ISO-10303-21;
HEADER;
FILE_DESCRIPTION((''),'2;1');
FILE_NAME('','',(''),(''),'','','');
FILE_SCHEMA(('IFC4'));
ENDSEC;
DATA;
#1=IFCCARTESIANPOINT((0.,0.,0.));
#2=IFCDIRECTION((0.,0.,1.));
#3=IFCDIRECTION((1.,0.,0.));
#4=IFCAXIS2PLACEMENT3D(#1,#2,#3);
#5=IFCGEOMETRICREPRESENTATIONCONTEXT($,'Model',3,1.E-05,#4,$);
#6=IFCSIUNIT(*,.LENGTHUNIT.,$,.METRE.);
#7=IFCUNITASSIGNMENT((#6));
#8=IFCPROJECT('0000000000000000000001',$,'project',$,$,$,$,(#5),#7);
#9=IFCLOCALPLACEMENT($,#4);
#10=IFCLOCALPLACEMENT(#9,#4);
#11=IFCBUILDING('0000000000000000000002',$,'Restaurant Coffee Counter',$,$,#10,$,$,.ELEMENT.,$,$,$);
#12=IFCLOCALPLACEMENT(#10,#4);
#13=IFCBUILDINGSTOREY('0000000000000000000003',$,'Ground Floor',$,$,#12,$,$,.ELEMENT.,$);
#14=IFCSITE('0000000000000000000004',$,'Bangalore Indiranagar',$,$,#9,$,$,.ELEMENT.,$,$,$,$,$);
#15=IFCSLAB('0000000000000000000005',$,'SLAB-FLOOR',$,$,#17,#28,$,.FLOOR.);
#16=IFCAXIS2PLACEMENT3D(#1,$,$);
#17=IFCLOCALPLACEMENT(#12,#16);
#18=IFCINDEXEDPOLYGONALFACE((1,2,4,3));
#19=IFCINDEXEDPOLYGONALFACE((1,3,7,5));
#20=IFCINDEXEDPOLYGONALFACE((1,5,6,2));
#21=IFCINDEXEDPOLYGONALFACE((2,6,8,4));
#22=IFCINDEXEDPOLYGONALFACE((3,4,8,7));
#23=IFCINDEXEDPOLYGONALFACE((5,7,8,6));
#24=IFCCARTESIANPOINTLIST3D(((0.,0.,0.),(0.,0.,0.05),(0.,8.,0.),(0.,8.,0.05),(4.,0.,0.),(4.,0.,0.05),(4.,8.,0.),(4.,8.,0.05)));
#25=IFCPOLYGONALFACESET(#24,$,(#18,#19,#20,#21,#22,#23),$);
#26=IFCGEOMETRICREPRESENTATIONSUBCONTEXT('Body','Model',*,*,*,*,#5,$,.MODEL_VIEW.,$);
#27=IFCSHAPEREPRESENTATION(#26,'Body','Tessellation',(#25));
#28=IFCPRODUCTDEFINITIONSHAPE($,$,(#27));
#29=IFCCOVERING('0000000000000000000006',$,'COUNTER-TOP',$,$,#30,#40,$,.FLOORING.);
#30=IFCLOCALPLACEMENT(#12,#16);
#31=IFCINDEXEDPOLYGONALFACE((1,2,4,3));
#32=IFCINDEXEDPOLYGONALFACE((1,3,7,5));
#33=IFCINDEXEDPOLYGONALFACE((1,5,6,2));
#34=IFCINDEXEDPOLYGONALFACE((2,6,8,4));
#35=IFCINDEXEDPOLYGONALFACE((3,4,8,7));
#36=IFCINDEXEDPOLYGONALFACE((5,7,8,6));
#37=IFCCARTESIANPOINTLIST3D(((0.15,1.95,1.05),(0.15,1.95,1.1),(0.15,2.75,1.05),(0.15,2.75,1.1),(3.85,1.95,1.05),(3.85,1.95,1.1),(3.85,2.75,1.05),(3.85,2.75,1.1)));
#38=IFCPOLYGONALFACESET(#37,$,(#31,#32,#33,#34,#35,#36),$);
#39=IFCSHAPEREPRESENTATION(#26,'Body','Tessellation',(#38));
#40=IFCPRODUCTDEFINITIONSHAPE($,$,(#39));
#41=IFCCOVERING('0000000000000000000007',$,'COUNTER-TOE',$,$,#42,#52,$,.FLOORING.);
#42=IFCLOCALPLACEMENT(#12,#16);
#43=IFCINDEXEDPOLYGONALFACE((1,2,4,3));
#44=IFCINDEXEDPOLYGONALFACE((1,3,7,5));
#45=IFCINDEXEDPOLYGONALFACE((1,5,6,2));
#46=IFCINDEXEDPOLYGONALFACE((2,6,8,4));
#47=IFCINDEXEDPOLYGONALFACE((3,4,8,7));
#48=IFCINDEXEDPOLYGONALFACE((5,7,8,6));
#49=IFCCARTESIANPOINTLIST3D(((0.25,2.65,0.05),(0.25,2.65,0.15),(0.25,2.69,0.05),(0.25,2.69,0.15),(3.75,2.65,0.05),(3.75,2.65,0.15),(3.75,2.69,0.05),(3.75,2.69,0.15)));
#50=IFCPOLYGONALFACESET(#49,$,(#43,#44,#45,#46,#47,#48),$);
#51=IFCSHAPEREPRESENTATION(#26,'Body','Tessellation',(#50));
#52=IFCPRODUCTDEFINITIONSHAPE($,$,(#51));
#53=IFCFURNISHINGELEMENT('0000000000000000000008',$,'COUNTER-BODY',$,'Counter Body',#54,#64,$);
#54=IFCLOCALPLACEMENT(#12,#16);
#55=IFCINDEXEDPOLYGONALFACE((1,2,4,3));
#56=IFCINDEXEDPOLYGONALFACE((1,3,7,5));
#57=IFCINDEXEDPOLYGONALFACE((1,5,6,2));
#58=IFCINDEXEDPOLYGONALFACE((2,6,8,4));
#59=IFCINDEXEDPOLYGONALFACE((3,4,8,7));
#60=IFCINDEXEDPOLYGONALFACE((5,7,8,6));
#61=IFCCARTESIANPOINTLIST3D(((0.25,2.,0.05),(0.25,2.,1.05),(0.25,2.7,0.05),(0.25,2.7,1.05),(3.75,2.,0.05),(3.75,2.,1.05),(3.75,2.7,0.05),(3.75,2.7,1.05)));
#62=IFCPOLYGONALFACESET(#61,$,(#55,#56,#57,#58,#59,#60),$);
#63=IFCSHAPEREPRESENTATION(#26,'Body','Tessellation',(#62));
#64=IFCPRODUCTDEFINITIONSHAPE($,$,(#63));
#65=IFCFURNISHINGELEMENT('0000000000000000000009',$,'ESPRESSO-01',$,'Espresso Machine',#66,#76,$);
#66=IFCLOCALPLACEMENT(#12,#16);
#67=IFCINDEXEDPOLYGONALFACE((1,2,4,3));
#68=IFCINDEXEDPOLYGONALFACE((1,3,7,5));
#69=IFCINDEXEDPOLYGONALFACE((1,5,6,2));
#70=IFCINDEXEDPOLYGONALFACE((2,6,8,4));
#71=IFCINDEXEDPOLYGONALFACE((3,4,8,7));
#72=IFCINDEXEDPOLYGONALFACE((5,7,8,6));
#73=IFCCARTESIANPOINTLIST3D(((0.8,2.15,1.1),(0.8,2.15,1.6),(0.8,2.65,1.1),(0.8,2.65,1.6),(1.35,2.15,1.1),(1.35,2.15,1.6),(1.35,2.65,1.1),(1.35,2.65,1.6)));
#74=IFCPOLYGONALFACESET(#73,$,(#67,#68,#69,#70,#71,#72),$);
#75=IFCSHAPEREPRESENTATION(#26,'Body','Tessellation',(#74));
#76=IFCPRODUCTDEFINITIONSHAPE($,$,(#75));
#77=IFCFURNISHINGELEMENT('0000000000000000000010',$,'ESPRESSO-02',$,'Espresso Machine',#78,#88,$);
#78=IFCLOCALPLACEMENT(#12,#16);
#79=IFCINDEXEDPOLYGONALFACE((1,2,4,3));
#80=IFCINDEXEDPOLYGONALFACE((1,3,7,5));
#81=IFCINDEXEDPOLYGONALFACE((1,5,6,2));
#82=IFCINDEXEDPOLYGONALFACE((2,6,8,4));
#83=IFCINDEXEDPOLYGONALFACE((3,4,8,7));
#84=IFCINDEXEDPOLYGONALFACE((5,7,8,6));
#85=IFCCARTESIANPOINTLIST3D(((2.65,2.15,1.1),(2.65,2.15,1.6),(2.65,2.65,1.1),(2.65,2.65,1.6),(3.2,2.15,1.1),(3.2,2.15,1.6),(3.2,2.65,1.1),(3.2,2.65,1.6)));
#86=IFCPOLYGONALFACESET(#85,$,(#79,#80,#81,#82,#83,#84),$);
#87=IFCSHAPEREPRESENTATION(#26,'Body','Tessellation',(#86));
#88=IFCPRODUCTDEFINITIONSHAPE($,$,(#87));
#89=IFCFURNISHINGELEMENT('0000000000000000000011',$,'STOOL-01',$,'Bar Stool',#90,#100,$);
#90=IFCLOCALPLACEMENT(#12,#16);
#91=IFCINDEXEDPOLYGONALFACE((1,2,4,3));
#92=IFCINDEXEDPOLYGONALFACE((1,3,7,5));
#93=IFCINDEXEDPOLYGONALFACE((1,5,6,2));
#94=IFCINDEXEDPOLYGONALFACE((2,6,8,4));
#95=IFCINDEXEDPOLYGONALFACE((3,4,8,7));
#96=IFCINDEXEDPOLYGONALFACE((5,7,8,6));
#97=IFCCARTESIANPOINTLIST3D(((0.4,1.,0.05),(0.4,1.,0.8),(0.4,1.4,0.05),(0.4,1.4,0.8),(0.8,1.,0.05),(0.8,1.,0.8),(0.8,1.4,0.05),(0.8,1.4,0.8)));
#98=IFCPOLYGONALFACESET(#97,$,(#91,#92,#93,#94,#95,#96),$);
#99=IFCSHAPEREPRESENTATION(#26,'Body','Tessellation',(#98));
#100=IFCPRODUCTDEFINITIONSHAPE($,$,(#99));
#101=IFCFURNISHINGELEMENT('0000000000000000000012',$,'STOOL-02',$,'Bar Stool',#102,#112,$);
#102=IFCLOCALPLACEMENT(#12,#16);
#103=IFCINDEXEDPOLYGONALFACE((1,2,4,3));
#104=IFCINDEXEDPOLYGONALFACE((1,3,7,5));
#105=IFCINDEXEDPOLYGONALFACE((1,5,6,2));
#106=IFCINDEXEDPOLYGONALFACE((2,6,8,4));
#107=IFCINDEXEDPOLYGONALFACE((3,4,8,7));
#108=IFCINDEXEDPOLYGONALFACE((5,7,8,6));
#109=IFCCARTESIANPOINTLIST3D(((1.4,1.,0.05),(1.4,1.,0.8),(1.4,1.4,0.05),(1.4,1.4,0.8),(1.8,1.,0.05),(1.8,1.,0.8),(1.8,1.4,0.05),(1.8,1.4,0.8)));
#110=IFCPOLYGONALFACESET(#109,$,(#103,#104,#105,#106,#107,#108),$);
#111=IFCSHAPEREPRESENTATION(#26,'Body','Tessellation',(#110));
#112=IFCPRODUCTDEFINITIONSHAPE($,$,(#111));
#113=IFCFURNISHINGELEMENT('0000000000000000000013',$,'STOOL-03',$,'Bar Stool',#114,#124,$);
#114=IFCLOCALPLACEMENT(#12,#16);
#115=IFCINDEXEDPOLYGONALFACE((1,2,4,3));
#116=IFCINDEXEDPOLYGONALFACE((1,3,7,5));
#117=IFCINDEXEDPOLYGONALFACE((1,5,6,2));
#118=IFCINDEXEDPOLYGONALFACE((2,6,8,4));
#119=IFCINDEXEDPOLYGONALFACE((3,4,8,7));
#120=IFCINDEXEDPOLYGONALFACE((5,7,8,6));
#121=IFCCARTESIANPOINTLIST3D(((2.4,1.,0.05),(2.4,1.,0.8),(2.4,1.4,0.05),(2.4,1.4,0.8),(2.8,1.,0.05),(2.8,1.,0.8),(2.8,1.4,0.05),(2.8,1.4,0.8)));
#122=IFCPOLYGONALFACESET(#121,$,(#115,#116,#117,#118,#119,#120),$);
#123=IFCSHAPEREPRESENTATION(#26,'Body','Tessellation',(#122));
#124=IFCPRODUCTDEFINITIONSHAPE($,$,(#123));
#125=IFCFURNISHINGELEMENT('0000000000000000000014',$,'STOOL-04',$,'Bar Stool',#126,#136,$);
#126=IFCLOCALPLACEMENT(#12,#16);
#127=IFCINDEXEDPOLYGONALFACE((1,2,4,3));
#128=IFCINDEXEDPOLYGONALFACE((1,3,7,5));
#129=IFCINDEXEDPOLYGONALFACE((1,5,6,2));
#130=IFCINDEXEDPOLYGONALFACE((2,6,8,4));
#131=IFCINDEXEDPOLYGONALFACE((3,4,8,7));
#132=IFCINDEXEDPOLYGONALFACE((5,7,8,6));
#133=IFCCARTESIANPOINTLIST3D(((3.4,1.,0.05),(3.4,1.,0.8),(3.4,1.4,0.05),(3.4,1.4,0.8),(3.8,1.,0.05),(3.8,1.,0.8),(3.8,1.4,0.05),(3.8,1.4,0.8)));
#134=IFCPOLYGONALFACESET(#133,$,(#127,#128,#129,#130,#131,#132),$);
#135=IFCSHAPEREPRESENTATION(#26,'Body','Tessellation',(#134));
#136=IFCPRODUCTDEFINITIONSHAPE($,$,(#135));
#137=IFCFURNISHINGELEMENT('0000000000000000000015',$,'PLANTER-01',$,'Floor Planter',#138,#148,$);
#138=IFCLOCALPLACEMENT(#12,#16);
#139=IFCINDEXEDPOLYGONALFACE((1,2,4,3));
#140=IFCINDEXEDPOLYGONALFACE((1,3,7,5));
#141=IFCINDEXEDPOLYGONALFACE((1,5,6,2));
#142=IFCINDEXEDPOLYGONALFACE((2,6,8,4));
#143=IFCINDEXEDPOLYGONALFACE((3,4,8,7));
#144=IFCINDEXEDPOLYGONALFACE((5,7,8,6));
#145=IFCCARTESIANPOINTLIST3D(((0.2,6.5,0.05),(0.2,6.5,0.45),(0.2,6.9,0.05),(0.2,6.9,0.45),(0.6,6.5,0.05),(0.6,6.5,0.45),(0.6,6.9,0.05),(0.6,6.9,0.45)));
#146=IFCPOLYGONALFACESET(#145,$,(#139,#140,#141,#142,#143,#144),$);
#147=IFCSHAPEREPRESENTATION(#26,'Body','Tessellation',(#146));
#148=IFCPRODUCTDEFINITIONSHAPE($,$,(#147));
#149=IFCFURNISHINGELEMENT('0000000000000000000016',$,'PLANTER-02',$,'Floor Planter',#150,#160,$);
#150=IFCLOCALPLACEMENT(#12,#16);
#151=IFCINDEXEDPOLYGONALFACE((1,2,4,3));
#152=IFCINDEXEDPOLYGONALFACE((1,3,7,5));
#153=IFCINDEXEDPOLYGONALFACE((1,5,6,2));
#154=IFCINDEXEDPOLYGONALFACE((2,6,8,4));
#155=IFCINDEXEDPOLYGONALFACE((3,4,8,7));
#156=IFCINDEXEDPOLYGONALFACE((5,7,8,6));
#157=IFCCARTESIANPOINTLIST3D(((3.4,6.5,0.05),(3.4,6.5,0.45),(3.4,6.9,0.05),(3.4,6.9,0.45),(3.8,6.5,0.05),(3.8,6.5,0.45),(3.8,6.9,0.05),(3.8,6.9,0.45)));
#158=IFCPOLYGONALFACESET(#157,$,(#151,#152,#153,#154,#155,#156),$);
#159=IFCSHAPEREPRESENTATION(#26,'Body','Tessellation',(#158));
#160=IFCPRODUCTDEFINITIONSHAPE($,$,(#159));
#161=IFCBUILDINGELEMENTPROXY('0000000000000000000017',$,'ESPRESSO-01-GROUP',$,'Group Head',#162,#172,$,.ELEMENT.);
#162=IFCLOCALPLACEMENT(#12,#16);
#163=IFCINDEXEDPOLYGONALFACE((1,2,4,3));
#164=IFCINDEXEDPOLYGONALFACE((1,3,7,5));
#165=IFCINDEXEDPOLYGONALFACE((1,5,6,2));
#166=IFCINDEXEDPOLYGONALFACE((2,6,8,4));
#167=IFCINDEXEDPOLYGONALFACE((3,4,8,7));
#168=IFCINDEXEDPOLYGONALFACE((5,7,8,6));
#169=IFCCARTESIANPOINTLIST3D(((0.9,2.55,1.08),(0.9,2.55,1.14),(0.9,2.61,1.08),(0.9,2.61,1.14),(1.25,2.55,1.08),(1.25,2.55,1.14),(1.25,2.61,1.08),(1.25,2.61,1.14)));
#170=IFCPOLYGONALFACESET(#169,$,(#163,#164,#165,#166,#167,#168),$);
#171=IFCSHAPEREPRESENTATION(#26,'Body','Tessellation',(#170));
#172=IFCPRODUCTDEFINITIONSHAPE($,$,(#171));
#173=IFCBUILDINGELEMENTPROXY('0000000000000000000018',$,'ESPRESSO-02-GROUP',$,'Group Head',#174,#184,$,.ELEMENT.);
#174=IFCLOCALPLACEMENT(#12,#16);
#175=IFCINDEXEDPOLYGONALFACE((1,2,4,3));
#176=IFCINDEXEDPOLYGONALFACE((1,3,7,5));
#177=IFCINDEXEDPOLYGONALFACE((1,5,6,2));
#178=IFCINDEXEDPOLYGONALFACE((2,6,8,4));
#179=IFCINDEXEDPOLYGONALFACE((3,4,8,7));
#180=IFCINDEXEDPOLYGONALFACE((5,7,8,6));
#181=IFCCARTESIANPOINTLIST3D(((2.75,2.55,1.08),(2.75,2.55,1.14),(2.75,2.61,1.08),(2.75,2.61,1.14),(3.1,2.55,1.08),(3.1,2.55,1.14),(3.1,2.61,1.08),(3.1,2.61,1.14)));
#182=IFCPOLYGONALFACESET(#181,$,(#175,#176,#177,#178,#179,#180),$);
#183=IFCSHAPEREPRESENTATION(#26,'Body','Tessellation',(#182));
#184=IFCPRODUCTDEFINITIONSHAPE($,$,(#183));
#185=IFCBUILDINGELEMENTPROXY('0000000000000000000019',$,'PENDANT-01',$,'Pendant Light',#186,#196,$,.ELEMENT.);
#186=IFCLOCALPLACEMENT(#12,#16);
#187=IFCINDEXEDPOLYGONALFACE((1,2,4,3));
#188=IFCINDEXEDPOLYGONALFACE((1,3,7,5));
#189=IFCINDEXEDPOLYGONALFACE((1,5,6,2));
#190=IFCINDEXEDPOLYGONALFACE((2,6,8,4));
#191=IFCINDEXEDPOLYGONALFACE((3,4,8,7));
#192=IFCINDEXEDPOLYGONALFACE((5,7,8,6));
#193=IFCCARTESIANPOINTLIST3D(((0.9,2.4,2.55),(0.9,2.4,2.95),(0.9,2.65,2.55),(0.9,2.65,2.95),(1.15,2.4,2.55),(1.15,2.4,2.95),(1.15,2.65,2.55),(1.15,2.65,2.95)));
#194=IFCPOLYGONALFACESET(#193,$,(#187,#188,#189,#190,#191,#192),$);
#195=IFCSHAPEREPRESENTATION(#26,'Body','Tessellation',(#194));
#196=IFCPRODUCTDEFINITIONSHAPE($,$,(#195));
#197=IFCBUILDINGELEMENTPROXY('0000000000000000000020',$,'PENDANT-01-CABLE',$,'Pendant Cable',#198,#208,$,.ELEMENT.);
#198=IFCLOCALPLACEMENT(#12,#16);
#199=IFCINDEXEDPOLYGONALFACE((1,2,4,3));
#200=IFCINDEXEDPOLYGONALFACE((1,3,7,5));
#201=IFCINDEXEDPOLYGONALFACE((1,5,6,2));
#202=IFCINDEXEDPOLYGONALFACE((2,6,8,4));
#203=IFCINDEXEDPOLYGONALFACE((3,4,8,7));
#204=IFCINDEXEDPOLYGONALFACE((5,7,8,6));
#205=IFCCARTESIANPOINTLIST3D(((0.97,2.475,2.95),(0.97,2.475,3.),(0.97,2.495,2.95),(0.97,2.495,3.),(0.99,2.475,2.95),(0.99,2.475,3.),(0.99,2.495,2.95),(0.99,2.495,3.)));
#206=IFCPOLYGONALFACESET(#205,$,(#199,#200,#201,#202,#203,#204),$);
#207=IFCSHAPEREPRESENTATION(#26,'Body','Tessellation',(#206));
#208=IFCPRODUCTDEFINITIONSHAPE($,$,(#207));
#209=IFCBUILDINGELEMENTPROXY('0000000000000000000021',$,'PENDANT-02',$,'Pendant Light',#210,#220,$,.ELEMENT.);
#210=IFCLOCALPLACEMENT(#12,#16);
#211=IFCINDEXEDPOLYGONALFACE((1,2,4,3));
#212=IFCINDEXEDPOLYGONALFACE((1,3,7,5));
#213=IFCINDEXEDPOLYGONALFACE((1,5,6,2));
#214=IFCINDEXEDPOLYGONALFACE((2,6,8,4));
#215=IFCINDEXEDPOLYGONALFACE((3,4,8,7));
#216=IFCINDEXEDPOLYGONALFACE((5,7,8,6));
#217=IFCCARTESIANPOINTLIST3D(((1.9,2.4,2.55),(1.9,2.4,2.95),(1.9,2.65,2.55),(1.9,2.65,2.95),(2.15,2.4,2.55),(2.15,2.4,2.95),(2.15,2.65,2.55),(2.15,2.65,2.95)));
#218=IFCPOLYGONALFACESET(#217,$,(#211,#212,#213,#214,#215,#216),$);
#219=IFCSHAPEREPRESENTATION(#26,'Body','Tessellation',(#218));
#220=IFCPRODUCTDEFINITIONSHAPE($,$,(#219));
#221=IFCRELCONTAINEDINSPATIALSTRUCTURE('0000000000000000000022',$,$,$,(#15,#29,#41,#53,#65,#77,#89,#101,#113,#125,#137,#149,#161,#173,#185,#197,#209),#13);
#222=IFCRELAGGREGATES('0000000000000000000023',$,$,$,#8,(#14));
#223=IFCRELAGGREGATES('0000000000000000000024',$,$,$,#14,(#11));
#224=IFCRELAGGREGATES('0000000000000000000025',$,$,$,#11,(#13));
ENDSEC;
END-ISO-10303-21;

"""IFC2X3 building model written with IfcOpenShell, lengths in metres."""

from ifc_helpers import new_model, si_unit, frame, frame_2d, origin, origin_with_axes, place, context, subcontext, project, spatial, rectangle, extrude, element, save


model = new_model("IFC2X3")

# Units and contexts
model_context = context("Model", 3, precision=1e-05, world=origin_with_axes())
body_context = subcontext(model_context, "Body", "Model", "MODEL_VIEW")
ifc_project = project(units=[si_unit("LENGTHUNIT", "METRE")], contexts=[model_context])

# Site, building, storey
site_placement = place(None, origin_with_axes())
site = spatial("IfcSite", under=ifc_project, at=site_placement, Name="Bangalore Indiranagar", CompositionType="ELEMENT")
building_placement = place(site_placement, origin_with_axes())
building = spatial("IfcBuilding", under=site, at=building_placement, Name="Restaurant Coffee Counter", CompositionType="ELEMENT")
storey_placement = place(building_placement, origin_with_axes())
storey = spatial("IfcBuildingStorey", under=building, at=storey_placement, Name="Ground Floor", CompositionType="ELEMENT")

# Slab
slab_placement = place(storey_placement, origin_with_axes())
element("IfcSlab", 1, at=slab_placement, inside=storey, Name="SLAB-FLOOR", PredefinedType="FLOOR", context=body_context, shape_type="SweptSolid", body=[
    extrude(rectangle(XDim=4.0, YDim=8.0, at=frame_2d((2.0, 4.0))), origin(), (0.0, 0.0, 1.0), 0.05),
])

# Coverings
covering_1_placement = place(storey_placement, frame((0.15, 1.95, 1.05), z_axis=(0.0, 0.0, 1.0), x_axis=(1.0, 0.0, 0.0)))
element("IfcCovering", 2, at=covering_1_placement, inside=storey, Name="COUNTER-TOP", PredefinedType="FLOORING", context=body_context, shape_type="SweptSolid", body=[
    extrude(rectangle(XDim=3.7, YDim=0.8, at=frame_2d((1.85, 0.4))), origin(), (0.0, 0.0, 1.0), 0.05),
])
covering_2_placement = place(storey_placement, frame((0.25, 2.65, 0.05), z_axis=(0.0, 0.0, 1.0), x_axis=(1.0, 0.0, 0.0)))
element("IfcCovering", 3, at=covering_2_placement, inside=storey, Name="COUNTER-TOE", PredefinedType="FLOORING", context=body_context, shape_type="SweptSolid", body=[
    extrude(rectangle(XDim=3.5, YDim=0.04, at=frame_2d((1.75, 0.02))), origin(), (0.0, 0.0, 1.0), 0.1),
])

# Furnishing elements
furnishing_placement = place(storey_placement, frame((0.25, 2.0, 0.05), z_axis=(0.0, 0.0, 1.0), x_axis=(1.0, 0.0, 0.0)))
element("IfcFurnishingElement", 4, at=furnishing_placement, inside=storey, Name="COUNTER-BODY", ObjectType="Counter Body", context=body_context, shape_type="SweptSolid", body=[
    extrude(rectangle(XDim=3.5, YDim=0.7, at=frame_2d((1.75, 0.35))), origin(), (0.0, 0.0, 1.0), 1.0),
])
for number, where, z_axis, x_axis, name in (
    (5, (0.8, 2.15, 1.1), (0.0, 0.0, 1.0), (1.0, 0.0, 0.0), "ESPRESSO-01"),
    (6, (2.65, 2.15, 1.1), (0.0, 0.0, 1.0), (1.0, 0.0, 0.0), "ESPRESSO-02"),
):
    element("IfcFurnishingElement", number, at=place(storey_placement, frame(where, z_axis=z_axis, x_axis=x_axis)), inside=storey, Name=name, ObjectType="Espresso Machine", context=body_context, shape_type="SweptSolid", body=[
        extrude(rectangle(XDim=0.55, YDim=0.5, at=frame_2d((0.275, 0.25))), origin(), (0.0, 0.0, 1.0), 0.5),
    ])
for number, where, z_axis, x_axis, name in (
    (7, (0.4, 1.0, 0.05), (0.0, 0.0, 1.0), (1.0, 0.0, 0.0), "STOOL-01"),
    (8, (1.4, 1.0, 0.05), (0.0, 0.0, 1.0), (1.0, 0.0, 0.0), "STOOL-02"),
    (9, (2.4, 1.0, 0.05), (0.0, 0.0, 1.0), (1.0, 0.0, 0.0), "STOOL-03"),
    (10, (3.4, 1.0, 0.05), (0.0, 0.0, 1.0), (1.0, 0.0, 0.0), "STOOL-04"),
):
    element("IfcFurnishingElement", number, at=place(storey_placement, frame(where, z_axis=z_axis, x_axis=x_axis)), inside=storey, Name=name, ObjectType="Bar Stool", context=body_context, shape_type="SweptSolid", body=[
        extrude(rectangle(XDim=0.4, YDim=0.4, at=frame_2d((0.2, 0.2))), origin(), (0.0, 0.0, 1.0), 0.75),
    ])
for number, where, z_axis, x_axis, name in (
    (11, (0.2, 6.5, 0.05), (0.0, 0.0, 1.0), (1.0, 0.0, 0.0), "PLANTER-01"),
    (12, (3.4, 6.5, 0.05), (0.0, 0.0, 1.0), (1.0, 0.0, 0.0), "PLANTER-02"),
):
    element("IfcFurnishingElement", number, at=place(storey_placement, frame(where, z_axis=z_axis, x_axis=x_axis)), inside=storey, Name=name, ObjectType="Floor Planter", context=body_context, shape_type="SweptSolid", body=[
        extrude(rectangle(XDim=0.4, YDim=0.4, at=frame_2d((0.2, 0.2))), origin(), (0.0, 0.0, 1.0), 0.4),
    ])

# Building element proxies
for number, where, z_axis, x_axis, name in (
    (13, (0.9, 2.55, 1.08), (0.0, 0.0, 1.0), (1.0, 0.0, 0.0), "ESPRESSO-01-GROUP"),
    (14, (2.75, 2.55, 1.08), (0.0, 0.0, 1.0), (1.0, 0.0, 0.0), "ESPRESSO-02-GROUP"),
):
    element("IfcBuildingElementProxy", number, at=place(storey_placement, frame(where, z_axis=z_axis, x_axis=x_axis)), inside=storey, Name=name, ObjectType="Group Head", CompositionType="ELEMENT", context=body_context, shape_type="SweptSolid", body=[
        extrude(rectangle(XDim=0.35, YDim=0.06, at=frame_2d((0.175, 0.03))), origin(), (0.0, 0.0, 1.0), 0.06),
    ])
proxy_1_placement = place(storey_placement, frame((0.9, 2.4, 2.55), z_axis=(0.0, 0.0, 1.0), x_axis=(1.0, 0.0, 0.0)))
element("IfcBuildingElementProxy", 15, at=proxy_1_placement, inside=storey, Name="PENDANT-01", ObjectType="Pendant Light", CompositionType="ELEMENT", context=body_context, shape_type="SweptSolid", body=[
    extrude(rectangle(XDim=0.25, YDim=0.25, at=frame_2d((0.125, 0.125))), origin(), (0.0, 0.0, 1.0), 0.4),
])
proxy_2_placement = place(storey_placement, frame((0.97, 2.475, 2.95), z_axis=(0.0, 0.0, 1.0), x_axis=(1.0, 0.0, 0.0)))
element("IfcBuildingElementProxy", 16, at=proxy_2_placement, inside=storey, Name="PENDANT-01-CABLE", ObjectType="Pendant Cable", CompositionType="ELEMENT", context=body_context, shape_type="SweptSolid", body=[
    extrude(rectangle(XDim=0.02, YDim=0.02, at=frame_2d((0.01, 0.01))), origin(), (0.0, 0.0, 1.0), 0.05),
])
proxy_3_placement = place(storey_placement, frame((1.9, 2.4, 2.55), z_axis=(0.0, 0.0, 1.0), x_axis=(1.0, 0.0, 0.0)))
element("IfcBuildingElementProxy", 17, at=proxy_3_placement, inside=storey, Name="PENDANT-02", ObjectType="Pendant Light", CompositionType="ELEMENT", context=body_context, shape_type="SweptSolid", body=[
    extrude(rectangle(XDim=0.25, YDim=0.25, at=frame_2d((0.125, 0.125))), origin(), (0.0, 0.0, 1.0), 0.4),
])

save(model, "model.ifc")
